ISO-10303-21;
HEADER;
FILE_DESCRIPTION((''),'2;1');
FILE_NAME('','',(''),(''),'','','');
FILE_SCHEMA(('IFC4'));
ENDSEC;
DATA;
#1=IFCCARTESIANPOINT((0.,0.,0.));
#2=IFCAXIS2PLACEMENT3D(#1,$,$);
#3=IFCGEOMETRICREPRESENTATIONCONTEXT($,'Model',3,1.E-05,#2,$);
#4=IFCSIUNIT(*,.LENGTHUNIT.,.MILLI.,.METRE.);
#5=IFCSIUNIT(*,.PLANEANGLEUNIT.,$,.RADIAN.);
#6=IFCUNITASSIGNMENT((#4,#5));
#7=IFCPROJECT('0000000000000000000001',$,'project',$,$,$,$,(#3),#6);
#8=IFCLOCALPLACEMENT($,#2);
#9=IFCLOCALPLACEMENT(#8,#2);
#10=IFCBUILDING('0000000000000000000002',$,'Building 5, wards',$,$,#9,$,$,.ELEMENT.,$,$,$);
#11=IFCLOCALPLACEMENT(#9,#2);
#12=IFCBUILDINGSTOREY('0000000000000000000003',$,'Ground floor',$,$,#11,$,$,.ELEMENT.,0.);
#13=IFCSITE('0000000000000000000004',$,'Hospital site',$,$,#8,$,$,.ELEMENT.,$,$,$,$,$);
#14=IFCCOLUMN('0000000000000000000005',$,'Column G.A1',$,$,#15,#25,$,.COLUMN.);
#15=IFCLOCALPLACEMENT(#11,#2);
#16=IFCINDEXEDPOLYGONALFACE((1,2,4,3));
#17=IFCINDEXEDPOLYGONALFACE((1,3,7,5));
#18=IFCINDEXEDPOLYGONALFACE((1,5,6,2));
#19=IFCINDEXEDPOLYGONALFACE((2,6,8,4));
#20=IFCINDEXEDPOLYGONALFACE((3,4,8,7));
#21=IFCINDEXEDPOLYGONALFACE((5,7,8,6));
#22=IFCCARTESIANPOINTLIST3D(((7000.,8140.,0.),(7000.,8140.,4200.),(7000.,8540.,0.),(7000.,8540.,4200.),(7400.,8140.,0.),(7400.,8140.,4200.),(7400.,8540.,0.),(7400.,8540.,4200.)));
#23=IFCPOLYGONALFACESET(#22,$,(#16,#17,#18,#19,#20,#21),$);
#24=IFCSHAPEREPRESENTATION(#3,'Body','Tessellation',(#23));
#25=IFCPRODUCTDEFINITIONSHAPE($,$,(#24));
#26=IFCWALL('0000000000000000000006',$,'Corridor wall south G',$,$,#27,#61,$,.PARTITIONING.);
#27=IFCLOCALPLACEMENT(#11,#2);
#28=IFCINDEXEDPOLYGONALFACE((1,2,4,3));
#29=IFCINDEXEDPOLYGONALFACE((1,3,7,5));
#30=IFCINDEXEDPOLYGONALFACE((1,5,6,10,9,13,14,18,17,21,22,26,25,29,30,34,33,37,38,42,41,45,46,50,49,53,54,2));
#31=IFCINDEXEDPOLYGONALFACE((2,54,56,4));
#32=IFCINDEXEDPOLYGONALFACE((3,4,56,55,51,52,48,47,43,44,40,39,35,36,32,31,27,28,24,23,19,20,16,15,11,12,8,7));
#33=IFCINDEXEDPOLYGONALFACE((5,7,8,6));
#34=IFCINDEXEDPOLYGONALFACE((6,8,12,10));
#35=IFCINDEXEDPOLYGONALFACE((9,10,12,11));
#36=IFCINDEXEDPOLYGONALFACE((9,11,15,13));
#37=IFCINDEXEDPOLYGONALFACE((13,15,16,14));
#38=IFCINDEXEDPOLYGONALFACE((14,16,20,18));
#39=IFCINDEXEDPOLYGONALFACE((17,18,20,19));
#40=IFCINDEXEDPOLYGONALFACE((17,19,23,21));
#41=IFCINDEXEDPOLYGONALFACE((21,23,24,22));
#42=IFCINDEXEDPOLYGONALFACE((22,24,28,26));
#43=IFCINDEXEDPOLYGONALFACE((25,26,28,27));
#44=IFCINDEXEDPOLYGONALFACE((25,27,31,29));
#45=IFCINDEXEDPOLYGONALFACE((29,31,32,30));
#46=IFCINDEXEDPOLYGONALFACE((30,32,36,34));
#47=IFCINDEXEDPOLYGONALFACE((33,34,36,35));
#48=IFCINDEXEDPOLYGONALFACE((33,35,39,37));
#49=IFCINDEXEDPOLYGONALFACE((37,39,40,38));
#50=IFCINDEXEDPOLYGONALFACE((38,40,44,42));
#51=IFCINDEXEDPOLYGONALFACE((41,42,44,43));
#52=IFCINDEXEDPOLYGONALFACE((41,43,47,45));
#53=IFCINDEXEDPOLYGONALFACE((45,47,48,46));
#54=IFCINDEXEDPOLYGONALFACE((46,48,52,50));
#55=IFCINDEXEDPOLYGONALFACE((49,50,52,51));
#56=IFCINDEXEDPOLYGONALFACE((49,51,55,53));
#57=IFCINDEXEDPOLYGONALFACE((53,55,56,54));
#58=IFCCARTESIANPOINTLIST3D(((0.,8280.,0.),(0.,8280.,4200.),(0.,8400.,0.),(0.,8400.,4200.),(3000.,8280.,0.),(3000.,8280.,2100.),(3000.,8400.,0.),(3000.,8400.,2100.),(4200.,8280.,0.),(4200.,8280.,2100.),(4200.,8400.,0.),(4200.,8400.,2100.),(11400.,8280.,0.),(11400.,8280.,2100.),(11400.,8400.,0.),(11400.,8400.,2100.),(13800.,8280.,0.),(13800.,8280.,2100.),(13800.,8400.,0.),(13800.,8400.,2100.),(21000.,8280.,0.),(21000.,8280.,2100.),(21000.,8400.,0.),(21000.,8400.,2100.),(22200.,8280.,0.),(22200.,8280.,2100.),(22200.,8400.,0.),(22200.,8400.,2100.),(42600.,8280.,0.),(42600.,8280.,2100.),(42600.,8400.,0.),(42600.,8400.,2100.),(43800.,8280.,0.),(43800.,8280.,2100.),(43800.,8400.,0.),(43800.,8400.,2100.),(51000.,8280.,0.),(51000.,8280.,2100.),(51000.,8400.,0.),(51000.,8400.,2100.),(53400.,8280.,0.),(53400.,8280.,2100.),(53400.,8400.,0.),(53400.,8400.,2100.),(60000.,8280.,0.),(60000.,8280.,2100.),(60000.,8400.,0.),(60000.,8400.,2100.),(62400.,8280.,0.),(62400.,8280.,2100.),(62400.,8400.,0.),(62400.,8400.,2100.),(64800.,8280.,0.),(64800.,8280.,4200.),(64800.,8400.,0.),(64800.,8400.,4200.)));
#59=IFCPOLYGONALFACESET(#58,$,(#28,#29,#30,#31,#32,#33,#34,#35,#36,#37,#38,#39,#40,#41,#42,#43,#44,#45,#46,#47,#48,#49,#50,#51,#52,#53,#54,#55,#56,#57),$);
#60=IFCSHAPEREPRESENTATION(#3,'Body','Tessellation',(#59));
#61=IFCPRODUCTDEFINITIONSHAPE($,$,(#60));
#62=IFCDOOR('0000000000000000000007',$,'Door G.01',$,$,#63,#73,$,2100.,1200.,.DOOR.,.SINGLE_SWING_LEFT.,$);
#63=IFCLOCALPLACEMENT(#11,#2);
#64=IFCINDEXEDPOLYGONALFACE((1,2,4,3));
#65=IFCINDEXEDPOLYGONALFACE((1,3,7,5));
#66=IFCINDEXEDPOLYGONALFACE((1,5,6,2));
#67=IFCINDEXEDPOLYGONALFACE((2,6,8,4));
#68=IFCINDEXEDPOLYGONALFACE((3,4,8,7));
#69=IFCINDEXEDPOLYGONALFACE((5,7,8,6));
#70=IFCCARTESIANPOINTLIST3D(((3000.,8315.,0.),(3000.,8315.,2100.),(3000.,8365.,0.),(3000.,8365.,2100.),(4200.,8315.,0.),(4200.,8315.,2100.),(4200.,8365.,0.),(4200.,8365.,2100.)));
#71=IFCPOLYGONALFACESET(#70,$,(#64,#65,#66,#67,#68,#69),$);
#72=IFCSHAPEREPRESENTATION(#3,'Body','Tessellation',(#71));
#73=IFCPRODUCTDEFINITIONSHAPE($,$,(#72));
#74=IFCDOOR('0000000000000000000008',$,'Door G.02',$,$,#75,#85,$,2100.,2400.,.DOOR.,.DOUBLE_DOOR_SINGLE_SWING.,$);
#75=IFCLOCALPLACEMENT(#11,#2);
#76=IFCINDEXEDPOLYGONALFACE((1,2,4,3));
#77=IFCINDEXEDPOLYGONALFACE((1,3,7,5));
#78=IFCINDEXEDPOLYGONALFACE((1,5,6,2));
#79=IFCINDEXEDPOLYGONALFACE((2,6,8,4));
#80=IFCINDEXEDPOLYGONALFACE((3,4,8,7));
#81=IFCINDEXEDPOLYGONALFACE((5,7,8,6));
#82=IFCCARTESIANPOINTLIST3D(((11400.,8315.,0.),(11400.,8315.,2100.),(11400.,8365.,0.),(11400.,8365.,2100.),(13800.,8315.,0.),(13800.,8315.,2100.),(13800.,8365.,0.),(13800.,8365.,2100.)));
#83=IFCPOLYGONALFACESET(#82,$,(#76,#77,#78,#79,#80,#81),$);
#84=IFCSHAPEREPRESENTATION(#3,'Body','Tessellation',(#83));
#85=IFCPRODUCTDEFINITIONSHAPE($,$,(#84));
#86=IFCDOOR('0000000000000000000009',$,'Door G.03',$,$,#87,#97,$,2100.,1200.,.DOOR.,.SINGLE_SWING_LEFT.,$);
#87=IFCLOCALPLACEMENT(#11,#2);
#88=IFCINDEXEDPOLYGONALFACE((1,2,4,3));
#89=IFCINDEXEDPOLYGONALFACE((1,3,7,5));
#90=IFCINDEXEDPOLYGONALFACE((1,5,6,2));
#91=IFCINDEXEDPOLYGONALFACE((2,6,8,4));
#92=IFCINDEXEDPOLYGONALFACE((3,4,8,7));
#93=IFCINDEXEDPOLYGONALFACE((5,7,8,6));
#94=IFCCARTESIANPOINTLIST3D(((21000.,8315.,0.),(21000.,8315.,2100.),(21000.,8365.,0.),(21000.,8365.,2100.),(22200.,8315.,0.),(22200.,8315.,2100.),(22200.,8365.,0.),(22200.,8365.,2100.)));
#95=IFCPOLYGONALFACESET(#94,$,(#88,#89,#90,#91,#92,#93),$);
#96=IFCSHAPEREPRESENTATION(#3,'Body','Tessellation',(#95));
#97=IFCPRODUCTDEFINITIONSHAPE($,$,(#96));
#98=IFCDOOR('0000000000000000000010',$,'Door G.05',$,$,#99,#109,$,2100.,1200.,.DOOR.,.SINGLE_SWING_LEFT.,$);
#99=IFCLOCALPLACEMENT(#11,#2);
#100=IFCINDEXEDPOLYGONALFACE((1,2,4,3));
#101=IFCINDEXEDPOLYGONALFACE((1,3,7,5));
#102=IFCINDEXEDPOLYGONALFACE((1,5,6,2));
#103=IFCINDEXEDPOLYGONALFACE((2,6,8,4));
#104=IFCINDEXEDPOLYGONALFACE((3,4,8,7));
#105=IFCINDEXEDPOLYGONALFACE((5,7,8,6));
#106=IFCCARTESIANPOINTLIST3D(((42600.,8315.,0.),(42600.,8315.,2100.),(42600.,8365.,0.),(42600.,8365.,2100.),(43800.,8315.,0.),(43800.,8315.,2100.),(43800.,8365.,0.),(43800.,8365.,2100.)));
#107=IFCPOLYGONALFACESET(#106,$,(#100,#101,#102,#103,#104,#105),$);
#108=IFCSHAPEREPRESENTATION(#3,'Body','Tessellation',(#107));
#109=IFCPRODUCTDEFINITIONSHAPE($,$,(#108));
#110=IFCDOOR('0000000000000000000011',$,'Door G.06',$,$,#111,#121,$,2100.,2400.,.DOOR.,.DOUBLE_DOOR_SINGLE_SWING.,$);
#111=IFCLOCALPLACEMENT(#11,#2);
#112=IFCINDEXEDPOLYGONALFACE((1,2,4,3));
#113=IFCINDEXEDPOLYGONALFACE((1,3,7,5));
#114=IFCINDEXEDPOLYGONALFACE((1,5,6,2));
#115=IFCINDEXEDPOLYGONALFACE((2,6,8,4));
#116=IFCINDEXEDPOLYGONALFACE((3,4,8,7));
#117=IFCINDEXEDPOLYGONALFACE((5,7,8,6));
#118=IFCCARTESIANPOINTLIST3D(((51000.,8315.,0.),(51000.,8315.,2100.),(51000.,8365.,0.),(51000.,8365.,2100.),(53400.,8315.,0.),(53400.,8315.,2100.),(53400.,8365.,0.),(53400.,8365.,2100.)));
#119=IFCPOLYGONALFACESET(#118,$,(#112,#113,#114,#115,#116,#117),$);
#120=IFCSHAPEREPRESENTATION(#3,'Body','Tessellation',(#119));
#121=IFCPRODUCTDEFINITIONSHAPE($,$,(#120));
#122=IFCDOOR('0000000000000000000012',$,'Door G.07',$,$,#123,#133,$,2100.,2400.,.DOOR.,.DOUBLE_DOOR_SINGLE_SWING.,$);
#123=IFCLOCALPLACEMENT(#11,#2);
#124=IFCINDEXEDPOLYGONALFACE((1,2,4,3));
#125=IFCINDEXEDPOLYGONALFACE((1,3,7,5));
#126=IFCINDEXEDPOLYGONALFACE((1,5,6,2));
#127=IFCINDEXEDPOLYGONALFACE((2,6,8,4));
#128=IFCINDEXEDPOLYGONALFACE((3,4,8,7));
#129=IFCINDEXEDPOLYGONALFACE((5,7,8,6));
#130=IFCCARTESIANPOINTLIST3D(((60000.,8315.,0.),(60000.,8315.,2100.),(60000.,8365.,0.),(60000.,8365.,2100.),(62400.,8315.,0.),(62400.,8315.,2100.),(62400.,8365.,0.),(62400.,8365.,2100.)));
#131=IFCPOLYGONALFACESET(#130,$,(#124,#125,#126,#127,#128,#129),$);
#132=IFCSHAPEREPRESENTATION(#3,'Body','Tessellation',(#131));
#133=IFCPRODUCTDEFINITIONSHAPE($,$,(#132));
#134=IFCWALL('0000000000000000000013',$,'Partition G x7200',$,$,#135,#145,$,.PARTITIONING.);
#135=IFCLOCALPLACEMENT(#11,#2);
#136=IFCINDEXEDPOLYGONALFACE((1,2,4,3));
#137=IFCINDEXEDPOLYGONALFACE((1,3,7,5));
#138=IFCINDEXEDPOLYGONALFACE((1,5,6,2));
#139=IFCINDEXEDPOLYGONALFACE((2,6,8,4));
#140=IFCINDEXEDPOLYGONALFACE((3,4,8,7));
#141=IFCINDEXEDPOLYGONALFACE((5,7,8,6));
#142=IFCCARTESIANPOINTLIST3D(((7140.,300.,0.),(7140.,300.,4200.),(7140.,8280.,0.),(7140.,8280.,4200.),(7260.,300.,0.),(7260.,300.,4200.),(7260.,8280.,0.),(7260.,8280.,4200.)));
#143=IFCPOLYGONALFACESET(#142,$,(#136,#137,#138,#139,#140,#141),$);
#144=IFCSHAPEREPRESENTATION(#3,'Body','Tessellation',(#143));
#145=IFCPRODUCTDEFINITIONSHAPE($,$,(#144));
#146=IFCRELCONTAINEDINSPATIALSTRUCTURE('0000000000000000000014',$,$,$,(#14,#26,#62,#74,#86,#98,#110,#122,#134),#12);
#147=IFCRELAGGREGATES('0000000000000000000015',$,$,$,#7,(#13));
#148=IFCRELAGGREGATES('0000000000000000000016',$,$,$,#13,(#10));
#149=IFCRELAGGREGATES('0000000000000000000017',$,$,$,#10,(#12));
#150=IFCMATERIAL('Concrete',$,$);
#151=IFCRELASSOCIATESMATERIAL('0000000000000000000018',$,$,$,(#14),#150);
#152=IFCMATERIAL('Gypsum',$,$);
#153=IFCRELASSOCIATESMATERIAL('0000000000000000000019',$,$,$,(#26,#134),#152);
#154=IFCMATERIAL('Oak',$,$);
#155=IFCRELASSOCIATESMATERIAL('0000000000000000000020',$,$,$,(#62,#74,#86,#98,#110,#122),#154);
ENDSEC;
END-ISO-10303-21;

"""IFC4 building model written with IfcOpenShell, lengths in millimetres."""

from ifc_helpers import new_model, si_unit, frame, frame_2d, origin, origin_2d, place, context, project, spatial, rectangle, extrude, material, element, fill, save


model = new_model("IFC4")

# Units and contexts
model_context = context("Model", 3, precision=1e-05, world=origin())
ifc_project = project(units=[si_unit("LENGTHUNIT", "METRE", prefix="MILLI"), si_unit("PLANEANGLEUNIT", "RADIAN")], contexts=[model_context])

# Site, building, storey
site_placement = place(None, origin())
site = spatial("IfcSite", under=ifc_project, at=site_placement, Name="Hospital site", CompositionType="ELEMENT")
building_placement = place(site_placement, origin())
building = spatial("IfcBuilding", under=site, at=building_placement, Name="Building 5, wards", CompositionType="ELEMENT")
storey_placement = place(building_placement, origin())
storey = spatial("IfcBuildingStorey", under=building, at=storey_placement, Name="Ground floor", CompositionType="ELEMENT", Elevation=0.0)

# Column
ifc_material_1 = material(Name="Concrete")
column_placement = place(storey_placement, frame((7200.0, 8340.0, 0.0)))
element("IfcColumn", 1, at=column_placement, inside=storey, material=ifc_material_1, Name="Column G.A1", PredefinedType="COLUMN", context=model_context, shape_type="SweptSolid", body=[
    extrude(rectangle(XDim=400.0, YDim=400.0, at=origin_2d()), origin(), (0.0, 0.0, 1.0), 4200.0),
])

# Wall, openings, doors
ifc_material_2 = material(Name="Gypsum")
wall_1_placement = place(storey_placement, frame((0.0, 8280.0, 0.0), x_axis=(1.0, 0.0, 0.0)))
wall_1 = element("IfcWall", 2, at=wall_1_placement, inside=storey, material=ifc_material_2, Name="Corridor wall south G", PredefinedType="PARTITIONING", context=model_context, shape_type="SweptSolid", body=[
    extrude(rectangle(XDim=64800.0, YDim=120.0, at=frame_2d((32400.0, 60.0))), origin(), (0.0, 0.0, 1.0), 4200.0),
])
opening_1_placement = place(wall_1_placement, frame((3000.0, -50.0, 0.0)))
opening_1 = element("IfcOpeningElement", 3, at=opening_1_placement, cuts=wall_1, PredefinedType="OPENING", context=model_context, shape_type="SweptSolid", body=[
    extrude(rectangle(XDim=1200.0, YDim=220.0, at=frame_2d((600.0, 110.0))), origin(), (0.0, 0.0, 1.0), 2100.0),
])
opening_2_placement = place(wall_1_placement, frame((11400.0, -50.0, 0.0)))
opening_2 = element("IfcOpeningElement", 4, at=opening_2_placement, cuts=wall_1, PredefinedType="OPENING", context=model_context, shape_type="SweptSolid", body=[
    extrude(rectangle(XDim=2400.0, YDim=220.0, at=frame_2d((1200.0, 110.0))), origin(), (0.0, 0.0, 1.0), 2100.0),
])
opening_3_placement = place(wall_1_placement, frame((21000.0, -50.0, 0.0)))
opening_3 = element("IfcOpeningElement", 5, at=opening_3_placement, cuts=wall_1, PredefinedType="OPENING", context=model_context, shape_type="SweptSolid", body=[
    extrude(rectangle(XDim=1200.0, YDim=220.0, at=frame_2d((600.0, 110.0))), origin(), (0.0, 0.0, 1.0), 2100.0),
])
opening_4_placement = place(wall_1_placement, frame((42600.0, -50.0, 0.0)))
opening_4 = element("IfcOpeningElement", 6, at=opening_4_placement, cuts=wall_1, PredefinedType="OPENING", context=model_context, shape_type="SweptSolid", body=[
    extrude(rectangle(XDim=1200.0, YDim=220.0, at=frame_2d((600.0, 110.0))), origin(), (0.0, 0.0, 1.0), 2100.0),
])
opening_5_placement = place(wall_1_placement, frame((51000.0, -50.0, 0.0)))
opening_5 = element("IfcOpeningElement", 7, at=opening_5_placement, cuts=wall_1, PredefinedType="OPENING", context=model_context, shape_type="SweptSolid", body=[
    extrude(rectangle(XDim=2400.0, YDim=220.0, at=frame_2d((1200.0, 110.0))), origin(), (0.0, 0.0, 1.0), 2100.0),
])
opening_6_placement = place(wall_1_placement, frame((60000.0, -50.0, 0.0)))
opening_6 = element("IfcOpeningElement", 8, at=opening_6_placement, cuts=wall_1, PredefinedType="OPENING", context=model_context, shape_type="SweptSolid", body=[
    extrude(rectangle(XDim=2400.0, YDim=220.0, at=frame_2d((1200.0, 110.0))), origin(), (0.0, 0.0, 1.0), 2100.0),
])
ifc_material_3 = material(Name="Oak")
door_1_placement = place(opening_1_placement, frame((0.0, 85.0, 0.0)))
door_1 = element("IfcDoor", 9, at=door_1_placement, inside=storey, material=ifc_material_3, Name="Door G.01", OperationType="SINGLE_SWING_LEFT", OverallHeight=2100.0, OverallWidth=1200.0, PredefinedType="DOOR", context=model_context, shape_type="SweptSolid", body=[
    extrude(rectangle(XDim=1200.0, YDim=50.0, at=frame_2d((600.0, 25.0))), origin(), (0.0, 0.0, 1.0), 2100.0),
])
fill(opening_1, door_1)
door_2_placement = place(opening_2_placement, frame((0.0, 85.0, 0.0)))
door_2 = element("IfcDoor", 10, at=door_2_placement, inside=storey, material=ifc_material_3, Name="Door G.02", OperationType="DOUBLE_DOOR_SINGLE_SWING", OverallHeight=2100.0, OverallWidth=2400.0, PredefinedType="DOOR", context=model_context, shape_type="SweptSolid", body=[
    extrude(rectangle(XDim=2400.0, YDim=50.0, at=frame_2d((1200.0, 25.0))), origin(), (0.0, 0.0, 1.0), 2100.0),
])
fill(opening_2, door_2)
door_3_placement = place(opening_3_placement, frame((0.0, 85.0, 0.0)))
door_3 = element("IfcDoor", 11, at=door_3_placement, inside=storey, material=ifc_material_3, Name="Door G.03", OperationType="SINGLE_SWING_LEFT", OverallHeight=2100.0, OverallWidth=1200.0, PredefinedType="DOOR", context=model_context, shape_type="SweptSolid", body=[
    extrude(rectangle(XDim=1200.0, YDim=50.0, at=frame_2d((600.0, 25.0))), origin(), (0.0, 0.0, 1.0), 2100.0),
])
fill(opening_3, door_3)
door_4_placement = place(opening_4_placement, frame((0.0, 85.0, 0.0)))
door_4 = element("IfcDoor", 12, at=door_4_placement, inside=storey, material=ifc_material_3, Name="Door G.05", OperationType="SINGLE_SWING_LEFT", OverallHeight=2100.0, OverallWidth=1200.0, PredefinedType="DOOR", context=model_context, shape_type="SweptSolid", body=[
    extrude(rectangle(XDim=1200.0, YDim=50.0, at=frame_2d((600.0, 25.0))), origin(), (0.0, 0.0, 1.0), 2100.0),
])
fill(opening_4, door_4)
door_5_placement = place(opening_5_placement, frame((0.0, 85.0, 0.0)))
door_5 = element("IfcDoor", 13, at=door_5_placement, inside=storey, material=ifc_material_3, Name="Door G.06", OperationType="DOUBLE_DOOR_SINGLE_SWING", OverallHeight=2100.0, OverallWidth=2400.0, PredefinedType="DOOR", context=model_context, shape_type="SweptSolid", body=[
    extrude(rectangle(XDim=2400.0, YDim=50.0, at=frame_2d((1200.0, 25.0))), origin(), (0.0, 0.0, 1.0), 2100.0),
])
fill(opening_5, door_5)
door_6_placement = place(opening_6_placement, frame((0.0, 85.0, 0.0)))
door_6 = element("IfcDoor", 14, at=door_6_placement, inside=storey, material=ifc_material_3, Name="Door G.07", OperationType="DOUBLE_DOOR_SINGLE_SWING", OverallHeight=2100.0, OverallWidth=2400.0, PredefinedType="DOOR", context=model_context, shape_type="SweptSolid", body=[
    extrude(rectangle(XDim=2400.0, YDim=50.0, at=frame_2d((1200.0, 25.0))), origin(), (0.0, 0.0, 1.0), 2100.0),
])
fill(opening_6, door_6)

# Wall
wall_2_placement = place(storey_placement, frame((7260.0, 300.0, 0.0), x_axis=(0.0, 1.0, 0.0)))
element("IfcWall", 15, at=wall_2_placement, inside=storey, material=ifc_material_2, Name="Partition G x7200", PredefinedType="PARTITIONING", context=model_context, shape_type="SweptSolid", body=[
    extrude(rectangle(XDim=7980.0, YDim=120.0, at=frame_2d((3990.0, 60.0))), origin(), (0.0, 0.0, 1.0), 4200.0),
])

save(model, "model.ifc")
